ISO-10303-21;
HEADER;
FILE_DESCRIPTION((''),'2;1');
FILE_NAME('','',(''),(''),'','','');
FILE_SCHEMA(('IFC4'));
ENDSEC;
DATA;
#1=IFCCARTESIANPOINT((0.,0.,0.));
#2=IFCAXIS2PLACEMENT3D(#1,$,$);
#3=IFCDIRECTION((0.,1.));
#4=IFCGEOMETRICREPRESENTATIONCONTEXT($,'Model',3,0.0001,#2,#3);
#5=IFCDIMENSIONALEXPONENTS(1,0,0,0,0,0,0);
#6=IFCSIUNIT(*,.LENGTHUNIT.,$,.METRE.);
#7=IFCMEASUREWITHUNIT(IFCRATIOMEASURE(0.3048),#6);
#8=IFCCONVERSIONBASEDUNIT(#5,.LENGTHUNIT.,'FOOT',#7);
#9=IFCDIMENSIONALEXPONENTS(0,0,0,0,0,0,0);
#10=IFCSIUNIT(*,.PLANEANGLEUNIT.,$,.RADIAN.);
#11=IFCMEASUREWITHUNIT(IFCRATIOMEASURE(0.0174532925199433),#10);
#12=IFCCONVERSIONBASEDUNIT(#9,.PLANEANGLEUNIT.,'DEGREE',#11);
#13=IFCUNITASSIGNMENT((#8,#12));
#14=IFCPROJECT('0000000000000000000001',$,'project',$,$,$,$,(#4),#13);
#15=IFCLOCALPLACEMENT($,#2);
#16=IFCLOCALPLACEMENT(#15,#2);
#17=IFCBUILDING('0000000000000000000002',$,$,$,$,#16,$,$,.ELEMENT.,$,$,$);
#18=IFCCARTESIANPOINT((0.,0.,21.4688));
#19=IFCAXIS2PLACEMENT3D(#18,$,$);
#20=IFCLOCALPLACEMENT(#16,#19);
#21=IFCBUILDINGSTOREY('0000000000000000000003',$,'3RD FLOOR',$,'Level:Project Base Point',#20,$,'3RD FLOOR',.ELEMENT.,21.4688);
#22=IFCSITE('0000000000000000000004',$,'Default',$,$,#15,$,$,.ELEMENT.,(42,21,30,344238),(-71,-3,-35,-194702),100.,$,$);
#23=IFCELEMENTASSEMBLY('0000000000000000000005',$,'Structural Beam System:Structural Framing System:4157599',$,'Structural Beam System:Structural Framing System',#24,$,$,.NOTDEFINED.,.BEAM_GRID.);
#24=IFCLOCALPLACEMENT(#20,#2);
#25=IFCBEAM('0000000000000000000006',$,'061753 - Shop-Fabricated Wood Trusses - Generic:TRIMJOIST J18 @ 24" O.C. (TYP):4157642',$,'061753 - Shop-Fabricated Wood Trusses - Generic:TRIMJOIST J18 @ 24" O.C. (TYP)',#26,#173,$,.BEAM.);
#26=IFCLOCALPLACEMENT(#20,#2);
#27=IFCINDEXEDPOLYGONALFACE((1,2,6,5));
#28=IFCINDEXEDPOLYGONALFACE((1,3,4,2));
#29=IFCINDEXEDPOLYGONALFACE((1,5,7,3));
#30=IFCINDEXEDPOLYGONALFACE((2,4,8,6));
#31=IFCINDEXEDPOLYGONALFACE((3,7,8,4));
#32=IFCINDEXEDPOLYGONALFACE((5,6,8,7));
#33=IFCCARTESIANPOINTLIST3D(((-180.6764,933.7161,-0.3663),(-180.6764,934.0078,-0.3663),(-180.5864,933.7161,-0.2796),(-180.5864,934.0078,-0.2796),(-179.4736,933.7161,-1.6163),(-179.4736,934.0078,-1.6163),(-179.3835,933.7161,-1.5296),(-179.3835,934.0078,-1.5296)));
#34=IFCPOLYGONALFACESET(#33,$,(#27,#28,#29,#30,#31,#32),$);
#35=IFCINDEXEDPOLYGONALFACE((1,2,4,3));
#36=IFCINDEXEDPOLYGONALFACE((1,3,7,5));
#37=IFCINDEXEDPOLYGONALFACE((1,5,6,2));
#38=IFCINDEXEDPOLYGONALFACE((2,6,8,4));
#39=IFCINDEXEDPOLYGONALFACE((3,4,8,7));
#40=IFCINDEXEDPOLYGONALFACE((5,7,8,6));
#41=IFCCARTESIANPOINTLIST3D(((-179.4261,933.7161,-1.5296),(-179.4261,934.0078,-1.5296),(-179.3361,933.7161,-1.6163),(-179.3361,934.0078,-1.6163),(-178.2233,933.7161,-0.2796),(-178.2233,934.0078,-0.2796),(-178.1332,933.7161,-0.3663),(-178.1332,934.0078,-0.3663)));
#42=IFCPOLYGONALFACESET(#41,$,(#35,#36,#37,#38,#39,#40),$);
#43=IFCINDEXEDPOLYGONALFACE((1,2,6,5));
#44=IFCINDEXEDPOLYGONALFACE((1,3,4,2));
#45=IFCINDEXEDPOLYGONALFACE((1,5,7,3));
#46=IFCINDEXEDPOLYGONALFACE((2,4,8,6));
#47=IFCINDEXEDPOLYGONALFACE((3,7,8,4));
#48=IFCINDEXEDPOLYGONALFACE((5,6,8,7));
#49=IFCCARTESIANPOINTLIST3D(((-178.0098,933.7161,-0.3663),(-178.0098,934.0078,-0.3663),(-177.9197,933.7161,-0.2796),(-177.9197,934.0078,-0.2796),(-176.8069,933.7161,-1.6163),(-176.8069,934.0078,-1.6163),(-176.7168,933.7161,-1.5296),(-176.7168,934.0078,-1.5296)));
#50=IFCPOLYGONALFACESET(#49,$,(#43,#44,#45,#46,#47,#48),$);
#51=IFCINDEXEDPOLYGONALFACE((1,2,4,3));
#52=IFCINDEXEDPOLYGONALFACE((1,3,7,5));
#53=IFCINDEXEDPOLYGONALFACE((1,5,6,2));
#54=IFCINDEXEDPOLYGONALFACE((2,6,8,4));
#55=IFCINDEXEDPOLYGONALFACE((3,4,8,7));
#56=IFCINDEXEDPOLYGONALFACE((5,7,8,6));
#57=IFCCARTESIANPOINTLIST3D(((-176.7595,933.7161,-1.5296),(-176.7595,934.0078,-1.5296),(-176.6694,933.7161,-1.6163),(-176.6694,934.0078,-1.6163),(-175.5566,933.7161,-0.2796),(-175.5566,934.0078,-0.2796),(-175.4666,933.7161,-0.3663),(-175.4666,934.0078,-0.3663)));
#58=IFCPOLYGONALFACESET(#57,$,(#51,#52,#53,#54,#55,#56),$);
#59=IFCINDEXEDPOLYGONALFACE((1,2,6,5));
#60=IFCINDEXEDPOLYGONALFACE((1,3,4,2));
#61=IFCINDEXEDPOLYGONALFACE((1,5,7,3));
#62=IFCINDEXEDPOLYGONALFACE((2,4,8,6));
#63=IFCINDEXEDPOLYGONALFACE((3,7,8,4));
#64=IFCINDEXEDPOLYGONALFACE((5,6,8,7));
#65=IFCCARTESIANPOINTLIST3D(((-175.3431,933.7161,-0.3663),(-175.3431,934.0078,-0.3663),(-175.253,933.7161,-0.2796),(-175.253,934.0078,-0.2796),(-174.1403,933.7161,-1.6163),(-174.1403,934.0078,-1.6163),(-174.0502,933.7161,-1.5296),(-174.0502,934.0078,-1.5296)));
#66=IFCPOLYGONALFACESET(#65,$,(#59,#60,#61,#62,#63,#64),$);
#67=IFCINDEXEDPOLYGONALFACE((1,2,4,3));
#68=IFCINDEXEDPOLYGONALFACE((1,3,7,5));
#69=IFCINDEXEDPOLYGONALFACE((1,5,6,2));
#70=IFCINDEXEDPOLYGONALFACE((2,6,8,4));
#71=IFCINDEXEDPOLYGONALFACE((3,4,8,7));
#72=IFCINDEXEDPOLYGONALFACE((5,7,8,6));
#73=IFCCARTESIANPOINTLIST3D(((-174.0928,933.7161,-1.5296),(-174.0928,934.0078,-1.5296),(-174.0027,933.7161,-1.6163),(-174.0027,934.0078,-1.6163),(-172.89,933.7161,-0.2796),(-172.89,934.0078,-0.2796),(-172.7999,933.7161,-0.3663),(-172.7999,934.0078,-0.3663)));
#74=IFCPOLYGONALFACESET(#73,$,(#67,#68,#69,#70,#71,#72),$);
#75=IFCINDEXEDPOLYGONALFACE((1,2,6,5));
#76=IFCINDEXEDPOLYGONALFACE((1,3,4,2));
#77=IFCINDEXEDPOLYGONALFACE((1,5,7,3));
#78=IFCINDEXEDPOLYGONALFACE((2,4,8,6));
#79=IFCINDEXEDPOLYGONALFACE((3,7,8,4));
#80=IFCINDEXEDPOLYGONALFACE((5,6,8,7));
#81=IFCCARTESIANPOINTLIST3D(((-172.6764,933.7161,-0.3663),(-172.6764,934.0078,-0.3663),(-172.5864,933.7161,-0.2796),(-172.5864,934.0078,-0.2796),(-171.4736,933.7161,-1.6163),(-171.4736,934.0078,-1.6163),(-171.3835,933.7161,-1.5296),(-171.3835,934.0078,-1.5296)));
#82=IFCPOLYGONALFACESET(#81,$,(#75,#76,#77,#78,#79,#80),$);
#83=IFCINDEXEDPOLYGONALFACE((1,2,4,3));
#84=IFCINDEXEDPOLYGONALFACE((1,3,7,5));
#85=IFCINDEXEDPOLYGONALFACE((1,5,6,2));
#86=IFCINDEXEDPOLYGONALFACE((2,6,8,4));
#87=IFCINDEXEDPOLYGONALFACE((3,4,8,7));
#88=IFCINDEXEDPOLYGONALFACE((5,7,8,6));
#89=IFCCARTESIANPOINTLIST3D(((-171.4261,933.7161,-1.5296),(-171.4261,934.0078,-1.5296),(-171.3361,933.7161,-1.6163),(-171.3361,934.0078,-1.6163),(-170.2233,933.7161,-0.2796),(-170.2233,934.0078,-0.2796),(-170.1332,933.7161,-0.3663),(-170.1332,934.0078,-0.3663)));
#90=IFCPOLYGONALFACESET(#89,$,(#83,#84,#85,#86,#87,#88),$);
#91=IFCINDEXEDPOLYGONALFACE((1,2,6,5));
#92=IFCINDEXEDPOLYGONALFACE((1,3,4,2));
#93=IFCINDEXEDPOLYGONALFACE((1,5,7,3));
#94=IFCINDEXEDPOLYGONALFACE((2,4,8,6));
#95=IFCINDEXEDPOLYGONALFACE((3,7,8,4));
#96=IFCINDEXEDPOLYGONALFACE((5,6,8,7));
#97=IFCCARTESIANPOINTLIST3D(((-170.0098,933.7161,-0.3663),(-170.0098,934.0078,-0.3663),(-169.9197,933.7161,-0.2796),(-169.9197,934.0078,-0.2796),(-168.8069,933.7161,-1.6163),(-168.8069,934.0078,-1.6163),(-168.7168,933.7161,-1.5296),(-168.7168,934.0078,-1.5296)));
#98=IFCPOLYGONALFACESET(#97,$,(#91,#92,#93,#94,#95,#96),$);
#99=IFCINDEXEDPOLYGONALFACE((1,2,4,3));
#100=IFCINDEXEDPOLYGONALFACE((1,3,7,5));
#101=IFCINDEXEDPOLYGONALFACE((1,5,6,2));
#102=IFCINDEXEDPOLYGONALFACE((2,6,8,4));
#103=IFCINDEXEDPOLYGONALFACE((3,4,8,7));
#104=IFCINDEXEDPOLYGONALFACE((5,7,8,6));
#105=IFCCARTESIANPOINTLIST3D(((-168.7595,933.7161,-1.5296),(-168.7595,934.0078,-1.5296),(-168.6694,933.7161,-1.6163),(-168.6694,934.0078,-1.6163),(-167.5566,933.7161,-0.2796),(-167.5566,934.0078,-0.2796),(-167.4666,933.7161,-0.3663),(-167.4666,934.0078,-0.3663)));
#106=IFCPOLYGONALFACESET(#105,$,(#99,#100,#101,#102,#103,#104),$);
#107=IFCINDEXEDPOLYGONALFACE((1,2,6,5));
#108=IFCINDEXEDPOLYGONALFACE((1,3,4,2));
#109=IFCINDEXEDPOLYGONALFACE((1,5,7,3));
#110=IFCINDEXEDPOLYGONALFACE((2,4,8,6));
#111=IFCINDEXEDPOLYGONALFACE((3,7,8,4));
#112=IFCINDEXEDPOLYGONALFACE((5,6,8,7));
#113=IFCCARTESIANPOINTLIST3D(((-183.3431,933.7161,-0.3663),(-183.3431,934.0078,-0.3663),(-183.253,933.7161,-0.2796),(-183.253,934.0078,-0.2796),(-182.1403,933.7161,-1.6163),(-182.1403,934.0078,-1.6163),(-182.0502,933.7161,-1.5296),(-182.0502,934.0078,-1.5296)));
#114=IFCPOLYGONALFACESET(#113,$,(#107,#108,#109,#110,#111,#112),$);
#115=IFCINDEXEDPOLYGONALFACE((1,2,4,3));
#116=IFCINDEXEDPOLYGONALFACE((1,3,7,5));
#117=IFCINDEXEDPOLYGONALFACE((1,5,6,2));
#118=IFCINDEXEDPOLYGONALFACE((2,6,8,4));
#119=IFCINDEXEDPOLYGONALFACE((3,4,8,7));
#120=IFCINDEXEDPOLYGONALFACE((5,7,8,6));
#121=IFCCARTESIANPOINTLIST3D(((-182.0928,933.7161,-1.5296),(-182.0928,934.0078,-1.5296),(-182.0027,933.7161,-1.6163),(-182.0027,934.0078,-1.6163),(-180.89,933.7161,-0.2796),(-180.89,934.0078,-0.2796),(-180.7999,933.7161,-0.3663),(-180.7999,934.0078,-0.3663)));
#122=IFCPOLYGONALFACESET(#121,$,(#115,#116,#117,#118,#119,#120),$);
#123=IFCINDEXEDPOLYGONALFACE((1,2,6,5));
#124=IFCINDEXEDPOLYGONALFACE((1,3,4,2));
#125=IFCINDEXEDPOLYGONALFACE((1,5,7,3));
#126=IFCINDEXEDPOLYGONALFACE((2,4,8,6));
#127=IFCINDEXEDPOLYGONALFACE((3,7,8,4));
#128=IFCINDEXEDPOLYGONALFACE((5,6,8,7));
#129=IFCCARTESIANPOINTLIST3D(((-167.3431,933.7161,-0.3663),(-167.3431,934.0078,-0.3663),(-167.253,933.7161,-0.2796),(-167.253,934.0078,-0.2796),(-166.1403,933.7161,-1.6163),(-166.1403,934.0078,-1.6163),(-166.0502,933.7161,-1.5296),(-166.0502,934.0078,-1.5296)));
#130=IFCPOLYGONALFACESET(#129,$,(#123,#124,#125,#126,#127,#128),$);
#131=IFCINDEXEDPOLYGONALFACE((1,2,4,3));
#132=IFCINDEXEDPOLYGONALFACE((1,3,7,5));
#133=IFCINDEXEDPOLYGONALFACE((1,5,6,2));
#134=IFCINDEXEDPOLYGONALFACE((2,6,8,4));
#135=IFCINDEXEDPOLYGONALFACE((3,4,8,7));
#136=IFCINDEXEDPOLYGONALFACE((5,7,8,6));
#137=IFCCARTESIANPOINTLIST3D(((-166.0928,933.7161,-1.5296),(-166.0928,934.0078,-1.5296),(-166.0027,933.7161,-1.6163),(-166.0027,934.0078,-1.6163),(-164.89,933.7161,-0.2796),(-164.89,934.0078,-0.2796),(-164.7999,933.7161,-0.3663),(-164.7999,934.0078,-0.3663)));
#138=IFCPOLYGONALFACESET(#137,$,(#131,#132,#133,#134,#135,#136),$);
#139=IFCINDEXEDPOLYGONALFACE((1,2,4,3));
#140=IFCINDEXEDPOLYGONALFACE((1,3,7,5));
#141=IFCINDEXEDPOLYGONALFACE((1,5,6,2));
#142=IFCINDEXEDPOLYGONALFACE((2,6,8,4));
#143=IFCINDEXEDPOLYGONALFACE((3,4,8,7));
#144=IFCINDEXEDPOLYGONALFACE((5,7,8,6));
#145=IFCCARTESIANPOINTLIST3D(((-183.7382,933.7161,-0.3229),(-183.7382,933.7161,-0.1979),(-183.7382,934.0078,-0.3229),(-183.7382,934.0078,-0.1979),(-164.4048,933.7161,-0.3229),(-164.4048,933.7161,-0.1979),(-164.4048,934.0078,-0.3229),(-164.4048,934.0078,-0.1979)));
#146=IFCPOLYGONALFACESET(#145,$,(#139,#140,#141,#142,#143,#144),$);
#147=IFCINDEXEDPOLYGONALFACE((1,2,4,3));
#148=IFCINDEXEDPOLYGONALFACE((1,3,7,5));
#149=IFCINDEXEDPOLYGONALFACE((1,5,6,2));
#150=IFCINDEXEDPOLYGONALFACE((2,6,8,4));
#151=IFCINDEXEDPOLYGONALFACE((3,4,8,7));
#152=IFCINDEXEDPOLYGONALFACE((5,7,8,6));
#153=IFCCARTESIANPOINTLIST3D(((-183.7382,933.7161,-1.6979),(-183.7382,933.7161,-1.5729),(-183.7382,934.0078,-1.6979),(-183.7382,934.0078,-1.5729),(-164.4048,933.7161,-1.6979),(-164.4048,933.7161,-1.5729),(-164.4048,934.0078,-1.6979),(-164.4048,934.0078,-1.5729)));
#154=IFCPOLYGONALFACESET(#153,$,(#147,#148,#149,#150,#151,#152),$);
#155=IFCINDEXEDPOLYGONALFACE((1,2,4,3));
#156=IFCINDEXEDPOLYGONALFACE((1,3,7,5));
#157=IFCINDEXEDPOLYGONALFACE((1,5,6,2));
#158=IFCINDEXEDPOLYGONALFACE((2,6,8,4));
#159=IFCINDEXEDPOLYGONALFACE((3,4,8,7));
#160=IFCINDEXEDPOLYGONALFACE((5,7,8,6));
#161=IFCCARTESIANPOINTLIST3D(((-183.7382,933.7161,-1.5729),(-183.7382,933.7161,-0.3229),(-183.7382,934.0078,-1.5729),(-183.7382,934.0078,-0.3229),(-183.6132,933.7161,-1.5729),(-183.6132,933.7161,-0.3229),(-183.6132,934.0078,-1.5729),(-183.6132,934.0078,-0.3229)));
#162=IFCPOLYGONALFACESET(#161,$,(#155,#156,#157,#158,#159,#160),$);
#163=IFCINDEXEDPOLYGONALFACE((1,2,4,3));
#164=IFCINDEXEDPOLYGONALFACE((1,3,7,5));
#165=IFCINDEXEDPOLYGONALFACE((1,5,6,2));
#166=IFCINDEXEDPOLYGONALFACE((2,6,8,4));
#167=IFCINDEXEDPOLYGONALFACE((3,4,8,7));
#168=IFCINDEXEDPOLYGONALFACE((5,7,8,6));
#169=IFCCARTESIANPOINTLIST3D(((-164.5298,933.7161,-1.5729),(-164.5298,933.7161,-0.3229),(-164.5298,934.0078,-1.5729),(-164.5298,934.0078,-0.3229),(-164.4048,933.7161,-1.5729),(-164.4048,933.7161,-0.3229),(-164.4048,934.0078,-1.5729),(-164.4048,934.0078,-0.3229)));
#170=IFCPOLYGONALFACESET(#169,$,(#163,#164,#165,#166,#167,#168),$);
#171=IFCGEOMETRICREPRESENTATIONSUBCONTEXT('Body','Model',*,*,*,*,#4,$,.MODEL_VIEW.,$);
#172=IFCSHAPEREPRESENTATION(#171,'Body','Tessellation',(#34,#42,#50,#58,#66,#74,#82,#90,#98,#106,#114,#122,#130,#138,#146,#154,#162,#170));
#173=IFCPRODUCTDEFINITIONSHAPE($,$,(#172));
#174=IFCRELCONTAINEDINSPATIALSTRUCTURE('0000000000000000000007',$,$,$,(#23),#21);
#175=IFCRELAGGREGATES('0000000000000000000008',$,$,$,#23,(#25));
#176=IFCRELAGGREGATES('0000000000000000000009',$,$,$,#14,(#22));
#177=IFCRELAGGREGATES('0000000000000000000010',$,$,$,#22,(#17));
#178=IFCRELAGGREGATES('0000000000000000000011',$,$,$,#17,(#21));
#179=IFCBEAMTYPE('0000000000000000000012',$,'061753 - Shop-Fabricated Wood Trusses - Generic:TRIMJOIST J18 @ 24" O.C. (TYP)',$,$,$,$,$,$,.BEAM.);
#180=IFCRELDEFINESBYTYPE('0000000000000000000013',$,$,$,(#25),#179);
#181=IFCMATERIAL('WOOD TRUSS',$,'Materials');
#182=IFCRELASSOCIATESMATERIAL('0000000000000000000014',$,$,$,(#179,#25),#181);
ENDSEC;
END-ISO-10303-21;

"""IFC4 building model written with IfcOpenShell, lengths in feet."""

from ifc_helpers import new_model, entity, si_unit, converted_unit, direction, frame, frame_2d, origin, origin_2d_with_axis, place, context, subcontext, project, spatial, rectangle, extrude, source, transform, mapped, material, material_profile, profile_set, profile_usage, type_object, type_shapes, element, aggregate, save


model = new_model("IFC4")

# Units and contexts
model_context = context("Model", 3, precision=0.0001, world=origin(), true_north=direction((0.0, 1.0)))
body_context = subcontext(model_context, "Body", "Model", "MODEL_VIEW")
ifc_project = project(units=[converted_unit("LENGTHUNIT", "FOOT", entity("IfcRatioMeasure", 0.3048), si_unit("LENGTHUNIT", "METRE"), dimensions=[1, 0, 0, 0, 0, 0, 0]), converted_unit("PLANEANGLEUNIT", "DEGREE", entity("IfcRatioMeasure", 0.0174532925199433), si_unit("PLANEANGLEUNIT", "RADIAN"), dimensions=[0, 0, 0, 0, 0, 0, 0])], contexts=[model_context])

# Site, building, storey
site_placement = place(None, origin())
site = spatial("IfcSite", under=ifc_project, at=site_placement, Name="Default", CompositionType="ELEMENT", RefLatitude=(42, 21, 30, 344238), RefLongitude=(-71, -3, -35, -194702), RefElevation=100.0)
building_placement = place(site_placement, origin())
building = spatial("IfcBuilding", under=site, at=building_placement, CompositionType="ELEMENT")
storey_placement = place(building_placement, frame((0.0, 0.0, 21.4688)))
storey = spatial("IfcBuildingStorey", under=building, at=storey_placement, Name="3RD FLOOR", ObjectType="Level:Project Base Point", LongName="3RD FLOOR", CompositionType="ELEMENT", Elevation=21.4688)

# Element assembly, beam
ifc_material = material(Name="WOOD TRUSS", Category="Materials")
ifc_material_profile_1 = material_profile(ifc_material, rectangle(XDim=1.7347, YDim=0.125, at=frame_2d((0.0, 0.0), x_axis=(1.0, 0.0))), Name="TRIMJOIST J18 @ 24\" O.C. (TYP)")
ifc_material_profile_2 = material_profile(ifc_material, rectangle(XDim=1.7347, YDim=0.125, at=frame_2d((0.0, 0.0), x_axis=(1.0, 0.0))), Name="TRIMJOIST J18 @ 24\" O.C. (TYP)")
ifc_material_profile_3 = material_profile(ifc_material, rectangle(XDim=1.7347, YDim=0.125, at=frame_2d((0.0, 0.0), x_axis=(1.0, 0.0))), Name="TRIMJOIST J18 @ 24\" O.C. (TYP)")
ifc_material_profile_4 = material_profile(ifc_material, rectangle(XDim=1.7347, YDim=0.125, at=frame_2d((0.0, 0.0), x_axis=(1.0, 0.0))), Name="TRIMJOIST J18 @ 24\" O.C. (TYP)")
ifc_material_profile_5 = material_profile(ifc_material, rectangle(XDim=1.7347, YDim=0.125, at=frame_2d((0.0, 0.0), x_axis=(1.0, 0.0))), Name="TRIMJOIST J18 @ 24\" O.C. (TYP)")
ifc_material_profile_6 = material_profile(ifc_material, rectangle(XDim=1.7347, YDim=0.125, at=frame_2d((0.0, 0.0), x_axis=(1.0, 0.0))), Name="TRIMJOIST J18 @ 24\" O.C. (TYP)")
ifc_material_profile_7 = material_profile(ifc_material, rectangle(XDim=1.7347, YDim=0.125, at=frame_2d((0.0, 0.0), x_axis=(1.0, 0.0))), Name="TRIMJOIST J18 @ 24\" O.C. (TYP)")
ifc_material_profile_8 = material_profile(ifc_material, rectangle(XDim=1.7347, YDim=0.125, at=frame_2d((0.0, 0.0), x_axis=(1.0, 0.0))), Name="TRIMJOIST J18 @ 24\" O.C. (TYP)")
ifc_material_profile_9 = material_profile(ifc_material, rectangle(XDim=1.7347, YDim=0.125, at=frame_2d((0.0, 0.0), x_axis=(1.0, 0.0))), Name="TRIMJOIST J18 @ 24\" O.C. (TYP)")
ifc_material_profile_10 = material_profile(ifc_material, rectangle(XDim=1.7347, YDim=0.125, at=origin_2d_with_axis()), Name="TRIMJOIST J18 @ 24\" O.C. (TYP)")
ifc_material_profile_11 = material_profile(ifc_material, rectangle(XDim=0.125, YDim=0.2917, at=origin_2d_with_axis()), Name="TRIMJOIST J18 @ 24\" O.C. (TYP)")
ifc_material_profile_12 = material_profile(ifc_material, rectangle(XDim=0.125, YDim=0.2917, at=origin_2d_with_axis()), Name="TRIMJOIST J18 @ 24\" O.C. (TYP)")
ifc_material_profile_13 = material_profile(ifc_material, rectangle(XDim=1.25, YDim=0.2917, at=origin_2d_with_axis()), Name="TRIMJOIST J18 @ 24\" O.C. (TYP)")
ifc_material_profile_14 = material_profile(ifc_material, rectangle(XDim=1.25, YDim=0.2917, at=origin_2d_with_axis()), Name="TRIMJOIST J18 @ 24\" O.C. (TYP)")
ifc_profile_set = profile_set([ifc_material_profile_1, ifc_material_profile_2, ifc_material_profile_3, ifc_material_profile_4, ifc_material_profile_5, ifc_material_profile_6, ifc_material_profile_7, ifc_material_profile_8, ifc_material_profile_9, ifc_material_profile_10, ifc_material_profile_11, ifc_material_profile_12, ifc_material_profile_13, ifc_material_profile_14], Name="TRIMJOIST J18 @ 24\" O.C. (TYP)")
assembly_1_placement = place(storey_placement, origin())
assembly_1 = element("IfcElementAssembly", 1, at=assembly_1_placement, inside=storey, Name="Structural Beam System:Structural Framing System:4157599", ObjectType="Structural Beam System:Structural Framing System", AssemblyPlace="NOTDEFINED", PredefinedType="BEAM_GRID")
beam_type_1 = type_object("IfcBeamType", Name="061753 - Shop-Fabricated Wood Trusses - Generic:TRIMJOIST J18 @ 24\" O.C. (TYP)", PredefinedType="BEAM", material=ifc_profile_set)
shared_shape_1 = source(origin(), body_context, "Body", "SweptSolid", [
    extrude(rectangle(XDim=1.7347, YDim=0.125, at=frame_2d((0.0, 0.0), x_axis=(1.0, 0.0))), frame((5.9585, -0.1458, 0.0), z_axis=(0.0, 1.0, 0.0), x_axis=(0.693383, 0.0, 0.720569)), (0.0, 0.0, 1.0), 0.2917),
    extrude(rectangle(XDim=1.7347, YDim=0.125, at=origin_2d_with_axis()), frame((4.7082, -0.1458, 0.0), z_axis=(0.0, 1.0, 0.0), x_axis=(0.693383, 0.0, -0.720569)), (0.0, 0.0, 1.0), 0.2917),
    extrude(rectangle(XDim=1.7347, YDim=0.125, at=frame_2d((0.0, 0.0), x_axis=(1.0, 0.0))), frame((3.2918, -0.1458, 0.0), z_axis=(0.0, 1.0, 0.0), x_axis=(0.693383, 0.0, 0.720569)), (0.0, 0.0, 1.0), 0.2917),
    extrude(rectangle(XDim=1.7347, YDim=0.125, at=frame_2d((0.0, 0.0), x_axis=(1.0, 0.0))), frame((2.0415, -0.1458, 0.0), z_axis=(0.0, 1.0, 0.0), x_axis=(0.693383, 0.0, -0.720569)), (0.0, 0.0, 1.0), 0.2917),
    extrude(rectangle(XDim=1.7347, YDim=0.125, at=frame_2d((0.0, 0.0), x_axis=(1.0, 0.0))), frame((0.6251, -0.1458, 0.0), z_axis=(0.0, 1.0, 0.0), x_axis=(0.693383, 0.0, 0.720569)), (0.0, 0.0, 1.0), 0.2917),
    extrude(rectangle(XDim=1.7347, YDim=0.125, at=frame_2d((0.0, 0.0), x_axis=(1.0, 0.0))), frame((-0.6251, -0.1458, 0.0), z_axis=(0.0, 1.0, 0.0), x_axis=(0.693383, 0.0, -0.720569)), (0.0, 0.0, 1.0), 0.2917),
    extrude(rectangle(XDim=1.7347, YDim=0.125, at=frame_2d((0.0, 0.0), x_axis=(1.0, 0.0))), frame((-2.0415, -0.1458, 0.0), z_axis=(0.0, 1.0, 0.0), x_axis=(0.693383, 0.0, 0.720569)), (0.0, 0.0, 1.0), 0.2917),
    extrude(rectangle(XDim=1.7347, YDim=0.125, at=origin_2d_with_axis()), frame((-3.2918, -0.1458, 0.0), z_axis=(0.0, 1.0, 0.0), x_axis=(0.693383, 0.0, -0.720569)), (0.0, 0.0, 1.0), 0.2917),
    extrude(rectangle(XDim=1.7347, YDim=0.125, at=frame_2d((0.0, 0.0), x_axis=(1.0, 0.0))), frame((-4.7082, -0.1458, 0.0), z_axis=(0.0, 1.0, 0.0), x_axis=(0.693383, 0.0, 0.720569)), (0.0, 0.0, 1.0), 0.2917),
    extrude(rectangle(XDim=1.7347, YDim=0.125, at=frame_2d((0.0, 0.0), x_axis=(1.0, 0.0))), frame((-5.9585, -0.1458, 0.0), z_axis=(0.0, 1.0, 0.0), x_axis=(0.693383, 0.0, -0.720569)), (0.0, 0.0, 1.0), 0.2917),
    extrude(rectangle(XDim=1.7347, YDim=0.125, at=frame_2d((0.0, 0.0), x_axis=(1.0, 0.0))), frame((8.6251, -0.1458, 0.0), z_axis=(0.0, 1.0, 0.0), x_axis=(0.693383, 0.0, 0.720569)), (0.0, 0.0, 1.0), 0.2917),
    extrude(rectangle(XDim=1.7347, YDim=0.125, at=origin_2d_with_axis()), frame((7.3749, -0.1458, 0.0), z_axis=(0.0, 1.0, 0.0), x_axis=(0.693383, 0.0, -0.720569)), (0.0, 0.0, 1.0), 0.2917),
    extrude(rectangle(XDim=1.7347, YDim=0.125, at=frame_2d((0.0, 0.0), x_axis=(1.0, 0.0))), frame((-7.3749, -0.1458, 0.0), z_axis=(0.0, 1.0, 0.0), x_axis=(0.693383, 0.0, 0.720569)), (0.0, 0.0, 1.0), 0.2917),
    extrude(rectangle(XDim=1.7347, YDim=0.125, at=origin_2d_with_axis()), frame((-8.6251, -0.1458, 0.0), z_axis=(0.0, 1.0, 0.0), x_axis=(0.693383, 0.0, -0.720569)), (0.0, 0.0, 1.0), 0.2917),
    extrude(rectangle(XDim=0.125, YDim=0.2917, at=origin_2d_with_axis()), frame((-9.6667, 0.0, 0.6875), z_axis=(1.0, 0.0, 0.0), x_axis=(0.0, 0.0, -1.0)), (0.0, 0.0, 1.0), 19.3333),
    extrude(rectangle(XDim=0.125, YDim=0.2917, at=origin_2d_with_axis()), frame((-9.6667, 0.0, -0.6875), z_axis=(1.0, 0.0, 0.0), x_axis=(0.0, 0.0, -1.0)), (0.0, 0.0, 1.0), 19.3333),
    extrude(rectangle(XDim=1.25, YDim=0.2917, at=origin_2d_with_axis()), frame((9.5417, 0.0, 0.0), z_axis=(1.0, 0.0, 0.0), x_axis=(0.0, 0.0, -1.0)), (0.0, 0.0, 1.0), 0.125),
    extrude(rectangle(XDim=1.25, YDim=0.2917, at=origin_2d_with_axis()), frame((-9.6667, 0.0, 0.0), z_axis=(1.0, 0.0, 0.0), x_axis=(0.0, 0.0, -1.0)), (0.0, 0.0, 1.0), 0.125),
])
type_shapes(beam_type_1, [shared_shape_1])
ifc_profile_usage_1 = profile_usage(ifc_profile_set, cardinal=8)
beam_1_placement = place(assembly_1_placement, frame((-174.0715, 933.8619, -0.9479), z_axis=(0.0, 0.0, 1.0), x_axis=(-1.0, 0.0, 0.0)))
beam_1 = element("IfcBeam", 2, at=beam_1_placement, type_object=beam_type_1, material=ifc_profile_usage_1, Name="061753 - Shop-Fabricated Wood Trusses - Generic:TRIMJOIST J18 @ 24\" O.C. (TYP):4157642", ObjectType="061753 - Shop-Fabricated Wood Trusses - Generic:TRIMJOIST J18 @ 24\" O.C. (TYP)", PredefinedType="BEAM", context=body_context, shape_type="MappedRepresentation", body=[
    mapped(shared_shape_1, transform((0.0, 0.0, 0.0), scale=1.0)),
])
aggregate(assembly_1, [beam_1])

save(model, "model.ifc")
